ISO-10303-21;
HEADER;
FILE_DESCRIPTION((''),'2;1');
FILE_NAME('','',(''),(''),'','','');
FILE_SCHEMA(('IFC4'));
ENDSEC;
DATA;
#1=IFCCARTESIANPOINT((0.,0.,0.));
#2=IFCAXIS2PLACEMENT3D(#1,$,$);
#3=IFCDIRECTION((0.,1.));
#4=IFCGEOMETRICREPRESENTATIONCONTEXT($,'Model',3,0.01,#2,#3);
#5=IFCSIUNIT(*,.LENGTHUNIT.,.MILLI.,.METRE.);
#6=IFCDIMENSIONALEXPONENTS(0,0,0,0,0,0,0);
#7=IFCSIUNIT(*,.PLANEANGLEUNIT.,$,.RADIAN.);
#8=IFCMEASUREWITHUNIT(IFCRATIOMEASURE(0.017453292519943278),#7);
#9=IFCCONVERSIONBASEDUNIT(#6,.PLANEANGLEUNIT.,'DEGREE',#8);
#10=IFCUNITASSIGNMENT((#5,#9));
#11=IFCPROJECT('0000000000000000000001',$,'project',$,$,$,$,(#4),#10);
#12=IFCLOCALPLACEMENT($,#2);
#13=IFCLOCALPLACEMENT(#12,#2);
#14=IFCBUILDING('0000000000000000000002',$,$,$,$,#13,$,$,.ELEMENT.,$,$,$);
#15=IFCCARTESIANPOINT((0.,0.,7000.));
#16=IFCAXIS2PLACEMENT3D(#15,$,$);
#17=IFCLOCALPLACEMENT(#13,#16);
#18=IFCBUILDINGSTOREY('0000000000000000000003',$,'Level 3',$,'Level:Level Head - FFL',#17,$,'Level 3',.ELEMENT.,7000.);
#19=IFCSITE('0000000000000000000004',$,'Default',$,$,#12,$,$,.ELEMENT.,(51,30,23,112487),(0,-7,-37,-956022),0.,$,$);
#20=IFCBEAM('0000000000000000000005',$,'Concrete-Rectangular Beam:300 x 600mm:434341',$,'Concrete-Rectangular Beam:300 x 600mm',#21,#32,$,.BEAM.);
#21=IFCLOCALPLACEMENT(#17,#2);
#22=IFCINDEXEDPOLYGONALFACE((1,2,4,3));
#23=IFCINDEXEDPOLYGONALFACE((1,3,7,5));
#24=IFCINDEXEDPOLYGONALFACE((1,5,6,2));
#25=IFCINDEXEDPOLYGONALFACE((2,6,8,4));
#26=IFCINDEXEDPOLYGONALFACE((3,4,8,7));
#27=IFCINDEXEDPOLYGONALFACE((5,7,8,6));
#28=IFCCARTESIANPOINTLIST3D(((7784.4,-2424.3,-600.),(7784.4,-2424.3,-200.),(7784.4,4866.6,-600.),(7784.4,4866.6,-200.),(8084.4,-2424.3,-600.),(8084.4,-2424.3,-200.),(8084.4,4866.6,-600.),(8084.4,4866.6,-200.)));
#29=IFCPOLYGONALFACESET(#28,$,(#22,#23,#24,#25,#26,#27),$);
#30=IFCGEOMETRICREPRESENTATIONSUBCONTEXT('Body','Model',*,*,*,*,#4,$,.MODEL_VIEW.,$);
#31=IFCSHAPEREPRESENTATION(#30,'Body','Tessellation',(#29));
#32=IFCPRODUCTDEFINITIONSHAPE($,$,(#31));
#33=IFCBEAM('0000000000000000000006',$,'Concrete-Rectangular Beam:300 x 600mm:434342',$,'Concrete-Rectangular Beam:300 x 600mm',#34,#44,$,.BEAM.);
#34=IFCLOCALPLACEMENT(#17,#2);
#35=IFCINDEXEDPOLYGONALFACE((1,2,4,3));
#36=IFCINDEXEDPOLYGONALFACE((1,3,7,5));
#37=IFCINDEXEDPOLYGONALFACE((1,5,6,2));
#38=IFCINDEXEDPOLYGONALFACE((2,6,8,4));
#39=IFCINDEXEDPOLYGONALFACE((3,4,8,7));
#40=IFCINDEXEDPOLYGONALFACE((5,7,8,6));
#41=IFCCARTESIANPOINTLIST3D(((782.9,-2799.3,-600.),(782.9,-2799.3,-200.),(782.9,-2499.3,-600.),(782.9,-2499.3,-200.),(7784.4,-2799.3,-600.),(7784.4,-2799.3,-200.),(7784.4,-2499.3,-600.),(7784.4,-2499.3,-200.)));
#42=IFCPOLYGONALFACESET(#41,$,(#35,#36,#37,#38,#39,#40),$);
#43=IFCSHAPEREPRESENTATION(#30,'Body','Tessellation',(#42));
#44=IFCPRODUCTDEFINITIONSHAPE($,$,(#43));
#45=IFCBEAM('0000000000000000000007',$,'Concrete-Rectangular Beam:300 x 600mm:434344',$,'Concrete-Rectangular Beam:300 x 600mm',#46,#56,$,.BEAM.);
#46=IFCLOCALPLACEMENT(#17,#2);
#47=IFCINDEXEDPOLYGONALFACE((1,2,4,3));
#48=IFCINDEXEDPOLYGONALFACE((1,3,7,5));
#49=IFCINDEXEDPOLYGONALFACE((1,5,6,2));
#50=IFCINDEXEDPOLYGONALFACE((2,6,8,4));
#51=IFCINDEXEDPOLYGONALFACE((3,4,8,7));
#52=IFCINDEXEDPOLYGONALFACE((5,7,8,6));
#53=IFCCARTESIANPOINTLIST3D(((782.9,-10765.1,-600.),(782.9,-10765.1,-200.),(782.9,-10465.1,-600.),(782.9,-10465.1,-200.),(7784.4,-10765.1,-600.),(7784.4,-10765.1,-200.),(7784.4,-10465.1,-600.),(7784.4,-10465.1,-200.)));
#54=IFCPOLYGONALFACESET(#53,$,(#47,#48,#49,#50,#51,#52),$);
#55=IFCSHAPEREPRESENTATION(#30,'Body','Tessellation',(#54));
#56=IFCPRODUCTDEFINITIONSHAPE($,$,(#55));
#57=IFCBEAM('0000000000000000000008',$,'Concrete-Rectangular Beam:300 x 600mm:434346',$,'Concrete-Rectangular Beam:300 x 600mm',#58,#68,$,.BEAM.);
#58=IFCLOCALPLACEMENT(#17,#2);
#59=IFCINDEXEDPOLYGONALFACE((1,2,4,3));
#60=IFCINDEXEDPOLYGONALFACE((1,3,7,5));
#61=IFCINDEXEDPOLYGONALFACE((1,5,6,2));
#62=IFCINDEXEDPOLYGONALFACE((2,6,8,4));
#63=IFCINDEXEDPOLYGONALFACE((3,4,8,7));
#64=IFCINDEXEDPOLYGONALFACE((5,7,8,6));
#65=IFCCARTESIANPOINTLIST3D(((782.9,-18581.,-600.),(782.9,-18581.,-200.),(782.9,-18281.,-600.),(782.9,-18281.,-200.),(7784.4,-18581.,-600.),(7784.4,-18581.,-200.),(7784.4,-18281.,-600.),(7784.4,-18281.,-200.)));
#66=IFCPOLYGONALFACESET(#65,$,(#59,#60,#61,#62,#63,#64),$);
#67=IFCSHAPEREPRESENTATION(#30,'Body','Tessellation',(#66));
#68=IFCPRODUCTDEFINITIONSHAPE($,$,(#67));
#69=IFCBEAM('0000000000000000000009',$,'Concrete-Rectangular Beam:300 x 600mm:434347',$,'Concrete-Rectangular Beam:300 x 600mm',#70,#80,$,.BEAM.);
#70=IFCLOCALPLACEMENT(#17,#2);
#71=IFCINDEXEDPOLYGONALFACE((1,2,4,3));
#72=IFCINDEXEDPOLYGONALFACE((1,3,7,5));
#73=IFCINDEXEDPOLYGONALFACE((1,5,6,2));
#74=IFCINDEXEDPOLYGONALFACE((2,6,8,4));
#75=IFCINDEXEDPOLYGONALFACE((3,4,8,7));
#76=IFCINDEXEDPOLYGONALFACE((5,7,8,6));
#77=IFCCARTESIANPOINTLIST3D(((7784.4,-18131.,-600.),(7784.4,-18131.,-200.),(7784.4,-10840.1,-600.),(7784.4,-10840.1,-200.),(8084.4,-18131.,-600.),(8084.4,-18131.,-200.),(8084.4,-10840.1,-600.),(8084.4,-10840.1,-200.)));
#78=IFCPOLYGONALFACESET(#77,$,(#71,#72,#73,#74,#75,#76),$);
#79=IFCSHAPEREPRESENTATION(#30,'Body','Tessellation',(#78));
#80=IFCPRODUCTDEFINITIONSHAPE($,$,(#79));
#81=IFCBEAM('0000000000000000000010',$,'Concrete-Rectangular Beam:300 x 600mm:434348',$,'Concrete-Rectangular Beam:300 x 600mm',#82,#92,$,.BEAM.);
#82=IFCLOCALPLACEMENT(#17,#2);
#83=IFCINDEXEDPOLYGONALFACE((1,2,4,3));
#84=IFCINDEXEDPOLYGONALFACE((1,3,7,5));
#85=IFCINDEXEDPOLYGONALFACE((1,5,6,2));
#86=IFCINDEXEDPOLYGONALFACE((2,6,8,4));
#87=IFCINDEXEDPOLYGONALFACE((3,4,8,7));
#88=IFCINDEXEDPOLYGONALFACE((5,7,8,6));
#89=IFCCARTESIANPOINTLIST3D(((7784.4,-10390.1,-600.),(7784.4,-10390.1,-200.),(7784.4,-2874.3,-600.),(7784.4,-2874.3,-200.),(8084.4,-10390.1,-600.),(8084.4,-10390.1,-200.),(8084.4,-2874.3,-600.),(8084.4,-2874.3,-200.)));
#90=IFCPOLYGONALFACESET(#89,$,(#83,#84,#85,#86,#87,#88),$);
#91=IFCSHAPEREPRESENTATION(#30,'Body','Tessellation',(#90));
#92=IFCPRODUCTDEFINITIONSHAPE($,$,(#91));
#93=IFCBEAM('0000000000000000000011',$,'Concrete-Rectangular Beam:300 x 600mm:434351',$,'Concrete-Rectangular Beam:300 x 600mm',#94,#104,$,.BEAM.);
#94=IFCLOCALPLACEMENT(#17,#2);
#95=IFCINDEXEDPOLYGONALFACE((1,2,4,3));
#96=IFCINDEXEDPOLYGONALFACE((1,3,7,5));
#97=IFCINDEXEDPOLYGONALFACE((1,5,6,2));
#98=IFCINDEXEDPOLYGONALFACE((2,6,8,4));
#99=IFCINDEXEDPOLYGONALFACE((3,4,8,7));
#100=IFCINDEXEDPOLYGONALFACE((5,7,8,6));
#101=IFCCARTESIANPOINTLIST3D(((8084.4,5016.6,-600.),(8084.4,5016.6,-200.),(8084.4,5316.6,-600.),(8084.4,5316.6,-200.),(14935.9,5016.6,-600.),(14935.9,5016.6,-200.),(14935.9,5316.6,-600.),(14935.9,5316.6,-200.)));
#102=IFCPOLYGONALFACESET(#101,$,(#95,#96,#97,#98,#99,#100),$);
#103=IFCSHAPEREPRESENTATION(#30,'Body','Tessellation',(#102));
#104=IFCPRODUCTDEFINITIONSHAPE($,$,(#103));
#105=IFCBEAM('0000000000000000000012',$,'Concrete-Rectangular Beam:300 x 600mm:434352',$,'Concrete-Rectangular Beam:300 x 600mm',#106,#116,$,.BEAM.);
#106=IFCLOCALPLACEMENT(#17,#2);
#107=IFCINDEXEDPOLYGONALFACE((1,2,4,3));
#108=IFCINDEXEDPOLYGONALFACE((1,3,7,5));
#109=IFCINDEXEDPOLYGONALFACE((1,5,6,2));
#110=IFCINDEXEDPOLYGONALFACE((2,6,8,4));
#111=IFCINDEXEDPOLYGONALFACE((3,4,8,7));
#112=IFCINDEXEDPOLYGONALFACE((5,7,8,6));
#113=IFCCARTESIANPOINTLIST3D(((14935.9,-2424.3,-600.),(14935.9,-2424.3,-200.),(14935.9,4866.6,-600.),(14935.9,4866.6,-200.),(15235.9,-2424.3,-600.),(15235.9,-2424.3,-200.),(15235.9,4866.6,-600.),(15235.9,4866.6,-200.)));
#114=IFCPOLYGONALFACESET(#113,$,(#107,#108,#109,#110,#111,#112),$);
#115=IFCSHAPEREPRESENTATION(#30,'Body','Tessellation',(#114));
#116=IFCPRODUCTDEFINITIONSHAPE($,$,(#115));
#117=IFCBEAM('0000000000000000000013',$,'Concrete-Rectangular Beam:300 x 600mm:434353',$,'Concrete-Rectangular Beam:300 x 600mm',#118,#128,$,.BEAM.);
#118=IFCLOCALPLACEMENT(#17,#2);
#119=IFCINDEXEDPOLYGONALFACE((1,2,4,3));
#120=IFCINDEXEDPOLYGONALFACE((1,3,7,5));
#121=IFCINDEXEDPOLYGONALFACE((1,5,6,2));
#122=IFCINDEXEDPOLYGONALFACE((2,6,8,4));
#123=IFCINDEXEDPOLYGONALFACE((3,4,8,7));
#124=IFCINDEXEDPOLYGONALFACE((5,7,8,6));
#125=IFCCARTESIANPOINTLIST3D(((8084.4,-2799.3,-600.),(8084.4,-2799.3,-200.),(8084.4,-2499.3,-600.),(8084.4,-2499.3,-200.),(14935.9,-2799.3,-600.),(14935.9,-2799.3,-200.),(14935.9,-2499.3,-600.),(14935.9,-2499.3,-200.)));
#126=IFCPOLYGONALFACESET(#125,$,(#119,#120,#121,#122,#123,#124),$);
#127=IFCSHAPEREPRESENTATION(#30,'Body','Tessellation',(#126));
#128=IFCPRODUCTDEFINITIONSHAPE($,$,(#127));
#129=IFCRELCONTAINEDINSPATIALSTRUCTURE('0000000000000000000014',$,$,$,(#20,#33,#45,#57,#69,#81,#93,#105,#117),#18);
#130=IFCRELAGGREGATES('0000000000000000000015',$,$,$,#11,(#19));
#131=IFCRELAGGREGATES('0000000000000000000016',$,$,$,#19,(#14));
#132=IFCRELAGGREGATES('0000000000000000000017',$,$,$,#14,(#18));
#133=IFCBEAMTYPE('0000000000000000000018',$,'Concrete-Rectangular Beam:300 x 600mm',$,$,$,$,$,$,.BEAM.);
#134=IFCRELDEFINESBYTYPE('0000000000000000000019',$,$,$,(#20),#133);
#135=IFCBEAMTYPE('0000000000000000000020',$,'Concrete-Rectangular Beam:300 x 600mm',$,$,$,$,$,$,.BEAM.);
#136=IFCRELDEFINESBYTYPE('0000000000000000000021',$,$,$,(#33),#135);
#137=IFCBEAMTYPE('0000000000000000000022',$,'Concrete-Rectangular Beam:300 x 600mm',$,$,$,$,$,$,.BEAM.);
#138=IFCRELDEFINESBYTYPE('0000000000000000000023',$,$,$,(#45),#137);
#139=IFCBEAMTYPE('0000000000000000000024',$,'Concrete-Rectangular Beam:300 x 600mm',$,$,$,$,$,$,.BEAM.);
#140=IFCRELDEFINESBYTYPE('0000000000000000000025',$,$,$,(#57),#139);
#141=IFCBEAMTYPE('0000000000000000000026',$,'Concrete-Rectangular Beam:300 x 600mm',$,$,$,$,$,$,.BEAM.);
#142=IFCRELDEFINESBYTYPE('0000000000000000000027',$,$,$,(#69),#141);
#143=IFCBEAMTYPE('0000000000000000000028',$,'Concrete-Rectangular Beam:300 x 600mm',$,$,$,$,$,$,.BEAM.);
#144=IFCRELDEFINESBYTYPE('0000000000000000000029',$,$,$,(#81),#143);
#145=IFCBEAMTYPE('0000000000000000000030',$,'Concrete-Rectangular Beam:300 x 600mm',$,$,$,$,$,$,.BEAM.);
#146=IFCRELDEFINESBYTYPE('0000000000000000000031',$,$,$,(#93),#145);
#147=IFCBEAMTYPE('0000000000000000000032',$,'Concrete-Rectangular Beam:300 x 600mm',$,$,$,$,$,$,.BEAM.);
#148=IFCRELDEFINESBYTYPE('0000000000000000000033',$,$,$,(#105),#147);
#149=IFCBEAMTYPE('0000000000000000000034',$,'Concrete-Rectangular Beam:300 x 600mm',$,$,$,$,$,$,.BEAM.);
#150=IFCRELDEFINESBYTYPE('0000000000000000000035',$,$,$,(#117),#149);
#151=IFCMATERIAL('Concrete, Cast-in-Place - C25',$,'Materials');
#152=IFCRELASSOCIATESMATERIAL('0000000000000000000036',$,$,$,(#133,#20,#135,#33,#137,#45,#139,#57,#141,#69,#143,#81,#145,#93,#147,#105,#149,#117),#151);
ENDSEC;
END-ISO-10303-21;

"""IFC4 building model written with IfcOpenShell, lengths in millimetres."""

from ifc_helpers import new_model, entity, si_unit, converted_unit, direction, frame, origin, place, context, subcontext, project, spatial, indexed_curve, outline, extrude, source, transform, mapped, material, type_object, type_shapes, element, save


model = new_model("IFC4")

# Units and contexts
model_context = context("Model", 3, precision=0.01, world=origin(), true_north=direction((0.0, 1.0)))
body_context = subcontext(model_context, "Body", "Model", "MODEL_VIEW")
ifc_project = project(units=[si_unit("LENGTHUNIT", "METRE", prefix="MILLI"), converted_unit("PLANEANGLEUNIT", "DEGREE", entity("IfcRatioMeasure", 0.017453292519943278), si_unit("PLANEANGLEUNIT", "RADIAN"), dimensions=[0, 0, 0, 0, 0, 0, 0])], contexts=[model_context])

# Site, building, storey
site_placement = place(None, origin())
site = spatial("IfcSite", under=ifc_project, at=site_placement, Name="Default", CompositionType="ELEMENT", RefLatitude=(51, 30, 23, 112487), RefLongitude=(0, -7, -37, -956022), RefElevation=0.0)
building_placement = place(site_placement, origin())
building = spatial("IfcBuilding", under=site, at=building_placement, CompositionType="ELEMENT")
storey_placement = place(building_placement, frame((0.0, 0.0, 7000.0)))
storey = spatial("IfcBuildingStorey", under=building, at=storey_placement, Name="Level 3", ObjectType="Level:Level Head - FFL", LongName="Level 3", CompositionType="ELEMENT", Elevation=7000.0)

# Beams
ifc_material = material(Name="Concrete, Cast-in-Place - C25", Category="Materials")
beam_type_1 = type_object("IfcBeamType", Name="Concrete-Rectangular Beam:300 x 600mm", PredefinedType="BEAM", material=ifc_material)
shared_shape_1 = source(origin(), body_context, "Body", "SweptSolid", [
    extrude(outline(indexed_curve([(-150.0, -200.0), (150.0, -200.0), (150.0, 200.0), (-150.0, 200.0), (-150.0, -200.0)], self_intersect=False)), frame((7934.4, 4866.6, 6600.0), z_axis=(0.0, -1.0, 0.0), x_axis=(-1.0, 0.0, 0.0)), (0.0, 0.0, 1.0), 7290.9),
])
type_shapes(beam_type_1, [shared_shape_1])
beam_1_placement = place(storey_placement, frame((0.0, 0.0, -7000.0)))
element("IfcBeam", 1, at=beam_1_placement, inside=storey, type_object=beam_type_1, material=ifc_material, Name="Concrete-Rectangular Beam:300 x 600mm:434341", ObjectType="Concrete-Rectangular Beam:300 x 600mm", PredefinedType="BEAM", context=body_context, shape_type="MappedRepresentation", body=[
    mapped(shared_shape_1, transform((0.0, 0.0, 0.0), scale=1.0)),
])
beam_type_2 = type_object("IfcBeamType", Name="Concrete-Rectangular Beam:300 x 600mm", PredefinedType="BEAM", material=ifc_material)
shared_shape_2 = source(origin(), body_context, "Body", "SweptSolid", [
    extrude(outline(indexed_curve([(-200.0, -150.0), (200.0, -150.0), (200.0, 150.0), (-200.0, 150.0), (-200.0, -150.0)], self_intersect=False)), frame((7784.4, -2649.3, 6600.0), z_axis=(-1.0, 0.0, 0.0), x_axis=(0.0, 0.0, -1.0)), (0.0, 0.0, 1.0), 7001.5),
])
type_shapes(beam_type_2, [shared_shape_2])
beam_2_placement = place(storey_placement, frame((0.0, 0.0, -7000.0)))
element("IfcBeam", 2, at=beam_2_placement, inside=storey, type_object=beam_type_2, material=ifc_material, Name="Concrete-Rectangular Beam:300 x 600mm:434342", ObjectType="Concrete-Rectangular Beam:300 x 600mm", PredefinedType="BEAM", context=body_context, shape_type="MappedRepresentation", body=[
    mapped(shared_shape_2, transform((0.0, 0.0, 0.0), scale=1.0)),
])
beam_type_3 = type_object("IfcBeamType", Name="Concrete-Rectangular Beam:300 x 600mm", PredefinedType="BEAM", material=ifc_material)
shared_shape_3 = source(origin(), body_context, "Body", "SweptSolid", [
    extrude(outline(indexed_curve([(-200.0, -150.0), (200.0, -150.0), (200.0, 150.0), (-200.0, 150.0), (-200.0, -150.0)], self_intersect=False)), frame((7784.4, -10615.1, 6600.0), z_axis=(-1.0, 0.0, 0.0), x_axis=(0.0, 0.0, -1.0)), (0.0, 0.0, 1.0), 7001.5),
])
type_shapes(beam_type_3, [shared_shape_3])
beam_3_placement = place(storey_placement, frame((0.0, 0.0, -7000.0)))
element("IfcBeam", 3, at=beam_3_placement, inside=storey, type_object=beam_type_3, material=ifc_material, Name="Concrete-Rectangular Beam:300 x 600mm:434344", ObjectType="Concrete-Rectangular Beam:300 x 600mm", PredefinedType="BEAM", context=body_context, shape_type="MappedRepresentation", body=[
    mapped(shared_shape_3, transform((0.0, 0.0, 0.0), scale=1.0)),
])
beam_type_4 = type_object("IfcBeamType", Name="Concrete-Rectangular Beam:300 x 600mm", PredefinedType="BEAM", material=ifc_material)
shared_shape_4 = source(origin(), body_context, "Body", "SweptSolid", [
    extrude(outline(indexed_curve([(-200.0, -150.0), (200.0, -150.0), (200.0, 150.0), (-200.0, 150.0), (-200.0, -150.0)], self_intersect=False)), frame((7784.4, -18431.0, 6600.0), z_axis=(-1.0, 0.0, 0.0), x_axis=(0.0, 0.0, -1.0)), (0.0, 0.0, 1.0), 7001.5),
])
type_shapes(beam_type_4, [shared_shape_4])
beam_4_placement = place(storey_placement, frame((0.0, 0.0, -7000.0)))
element("IfcBeam", 4, at=beam_4_placement, inside=storey, type_object=beam_type_4, material=ifc_material, Name="Concrete-Rectangular Beam:300 x 600mm:434346", ObjectType="Concrete-Rectangular Beam:300 x 600mm", PredefinedType="BEAM", context=body_context, shape_type="MappedRepresentation", body=[
    mapped(shared_shape_4, transform((0.0, 0.0, 0.0), scale=1.0)),
])
beam_type_5 = type_object("IfcBeamType", Name="Concrete-Rectangular Beam:300 x 600mm", PredefinedType="BEAM", material=ifc_material)
shared_shape_5 = source(origin(), body_context, "Body", "SweptSolid", [
    extrude(outline(indexed_curve([(-150.0, -200.0), (150.0, -200.0), (150.0, 200.0), (-150.0, 200.0), (-150.0, -200.0)], self_intersect=False)), frame((7934.4, -18131.0, 6600.0), z_axis=(0.0, 1.0, 0.0), x_axis=(-1.0, 0.0, 0.0)), (0.0, 0.0, 1.0), 7290.9),
])
type_shapes(beam_type_5, [shared_shape_5])
beam_5_placement = place(storey_placement, frame((0.0, 0.0, -7000.0)))
element("IfcBeam", 5, at=beam_5_placement, inside=storey, type_object=beam_type_5, material=ifc_material, Name="Concrete-Rectangular Beam:300 x 600mm:434347", ObjectType="Concrete-Rectangular Beam:300 x 600mm", PredefinedType="BEAM", context=body_context, shape_type="MappedRepresentation", body=[
    mapped(shared_shape_5, transform((0.0, 0.0, 0.0), scale=1.0)),
])
beam_type_6 = type_object("IfcBeamType", Name="Concrete-Rectangular Beam:300 x 600mm", PredefinedType="BEAM", material=ifc_material)
shared_shape_6 = source(origin(), body_context, "Body", "SweptSolid", [
    extrude(outline(indexed_curve([(-150.0, -200.0), (150.0, -200.0), (150.0, 200.0), (-150.0, 200.0), (-150.0, -200.0)], self_intersect=False)), frame((7934.4, -10390.1, 6600.0), z_axis=(0.0, 1.0, 0.0), x_axis=(-1.0, 0.0, 0.0)), (0.0, 0.0, 1.0), 7515.9),
])
type_shapes(beam_type_6, [shared_shape_6])
beam_6_placement = place(storey_placement, frame((0.0, 0.0, -7000.0)))
element("IfcBeam", 6, at=beam_6_placement, inside=storey, type_object=beam_type_6, material=ifc_material, Name="Concrete-Rectangular Beam:300 x 600mm:434348", ObjectType="Concrete-Rectangular Beam:300 x 600mm", PredefinedType="BEAM", context=body_context, shape_type="MappedRepresentation", body=[
    mapped(shared_shape_6, transform((0.0, 0.0, 0.0), scale=1.0)),
])
beam_type_7 = type_object("IfcBeamType", Name="Concrete-Rectangular Beam:300 x 600mm", PredefinedType="BEAM", material=ifc_material)
shared_shape_7 = source(origin(), body_context, "Body", "SweptSolid", [
    extrude(outline(indexed_curve([(-200.0, -150.0), (200.0, -150.0), (200.0, 150.0), (-200.0, 150.0), (-200.0, -150.0)], self_intersect=False)), frame((8084.4, 5166.6, 6600.0), z_axis=(1.0, 0.0, 0.0), x_axis=(0.0, 0.0, -1.0)), (0.0, 0.0, 1.0), 6851.5),
])
type_shapes(beam_type_7, [shared_shape_7])
beam_7_placement = place(storey_placement, frame((0.0, 0.0, -7000.0)))
element("IfcBeam", 7, at=beam_7_placement, inside=storey, type_object=beam_type_7, material=ifc_material, Name="Concrete-Rectangular Beam:300 x 600mm:434351", ObjectType="Concrete-Rectangular Beam:300 x 600mm", PredefinedType="BEAM", context=body_context, shape_type="MappedRepresentation", body=[
    mapped(shared_shape_7, transform((0.0, 0.0, 0.0), scale=1.0)),
])
beam_type_8 = type_object("IfcBeamType", Name="Concrete-Rectangular Beam:300 x 600mm", PredefinedType="BEAM", material=ifc_material)
shared_shape_8 = source(origin(), body_context, "Body", "SweptSolid", [
    extrude(outline(indexed_curve([(-150.0, -200.0), (150.0, -200.0), (150.0, 200.0), (-150.0, 200.0), (-150.0, -200.0)], self_intersect=False)), frame((15085.9, 4866.6, 6600.0), z_axis=(0.0, -1.0, 0.0), x_axis=(-1.0, 0.0, 0.0)), (0.0, 0.0, 1.0), 7290.9),
])
type_shapes(beam_type_8, [shared_shape_8])
beam_8_placement = place(storey_placement, frame((0.0, 0.0, -7000.0)))
element("IfcBeam", 8, at=beam_8_placement, inside=storey, type_object=beam_type_8, material=ifc_material, Name="Concrete-Rectangular Beam:300 x 600mm:434352", ObjectType="Concrete-Rectangular Beam:300 x 600mm", PredefinedType="BEAM", context=body_context, shape_type="MappedRepresentation", body=[
    mapped(shared_shape_8, transform((0.0, 0.0, 0.0), scale=1.0)),
])
beam_type_9 = type_object("IfcBeamType", Name="Concrete-Rectangular Beam:300 x 600mm", PredefinedType="BEAM", material=ifc_material)
shared_shape_9 = source(origin(), body_context, "Body", "SweptSolid", [
    extrude(outline(indexed_curve([(-200.0, -150.0), (200.0, -150.0), (200.0, 150.0), (-200.0, 150.0), (-200.0, -150.0)], self_intersect=False)), frame((14935.9, -2649.3, 6600.0), z_axis=(-1.0, 0.0, 0.0), x_axis=(0.0, 0.0, -1.0)), (0.0, 0.0, 1.0), 6851.5),
])
type_shapes(beam_type_9, [shared_shape_9])
beam_9_placement = place(storey_placement, frame((0.0, 0.0, -7000.0)))
element("IfcBeam", 9, at=beam_9_placement, inside=storey, type_object=beam_type_9, material=ifc_material, Name="Concrete-Rectangular Beam:300 x 600mm:434353", ObjectType="Concrete-Rectangular Beam:300 x 600mm", PredefinedType="BEAM", context=body_context, shape_type="MappedRepresentation", body=[
    mapped(shared_shape_9, transform((0.0, 0.0, 0.0), scale=1.0)),
])

save(model, "model.ifc")
